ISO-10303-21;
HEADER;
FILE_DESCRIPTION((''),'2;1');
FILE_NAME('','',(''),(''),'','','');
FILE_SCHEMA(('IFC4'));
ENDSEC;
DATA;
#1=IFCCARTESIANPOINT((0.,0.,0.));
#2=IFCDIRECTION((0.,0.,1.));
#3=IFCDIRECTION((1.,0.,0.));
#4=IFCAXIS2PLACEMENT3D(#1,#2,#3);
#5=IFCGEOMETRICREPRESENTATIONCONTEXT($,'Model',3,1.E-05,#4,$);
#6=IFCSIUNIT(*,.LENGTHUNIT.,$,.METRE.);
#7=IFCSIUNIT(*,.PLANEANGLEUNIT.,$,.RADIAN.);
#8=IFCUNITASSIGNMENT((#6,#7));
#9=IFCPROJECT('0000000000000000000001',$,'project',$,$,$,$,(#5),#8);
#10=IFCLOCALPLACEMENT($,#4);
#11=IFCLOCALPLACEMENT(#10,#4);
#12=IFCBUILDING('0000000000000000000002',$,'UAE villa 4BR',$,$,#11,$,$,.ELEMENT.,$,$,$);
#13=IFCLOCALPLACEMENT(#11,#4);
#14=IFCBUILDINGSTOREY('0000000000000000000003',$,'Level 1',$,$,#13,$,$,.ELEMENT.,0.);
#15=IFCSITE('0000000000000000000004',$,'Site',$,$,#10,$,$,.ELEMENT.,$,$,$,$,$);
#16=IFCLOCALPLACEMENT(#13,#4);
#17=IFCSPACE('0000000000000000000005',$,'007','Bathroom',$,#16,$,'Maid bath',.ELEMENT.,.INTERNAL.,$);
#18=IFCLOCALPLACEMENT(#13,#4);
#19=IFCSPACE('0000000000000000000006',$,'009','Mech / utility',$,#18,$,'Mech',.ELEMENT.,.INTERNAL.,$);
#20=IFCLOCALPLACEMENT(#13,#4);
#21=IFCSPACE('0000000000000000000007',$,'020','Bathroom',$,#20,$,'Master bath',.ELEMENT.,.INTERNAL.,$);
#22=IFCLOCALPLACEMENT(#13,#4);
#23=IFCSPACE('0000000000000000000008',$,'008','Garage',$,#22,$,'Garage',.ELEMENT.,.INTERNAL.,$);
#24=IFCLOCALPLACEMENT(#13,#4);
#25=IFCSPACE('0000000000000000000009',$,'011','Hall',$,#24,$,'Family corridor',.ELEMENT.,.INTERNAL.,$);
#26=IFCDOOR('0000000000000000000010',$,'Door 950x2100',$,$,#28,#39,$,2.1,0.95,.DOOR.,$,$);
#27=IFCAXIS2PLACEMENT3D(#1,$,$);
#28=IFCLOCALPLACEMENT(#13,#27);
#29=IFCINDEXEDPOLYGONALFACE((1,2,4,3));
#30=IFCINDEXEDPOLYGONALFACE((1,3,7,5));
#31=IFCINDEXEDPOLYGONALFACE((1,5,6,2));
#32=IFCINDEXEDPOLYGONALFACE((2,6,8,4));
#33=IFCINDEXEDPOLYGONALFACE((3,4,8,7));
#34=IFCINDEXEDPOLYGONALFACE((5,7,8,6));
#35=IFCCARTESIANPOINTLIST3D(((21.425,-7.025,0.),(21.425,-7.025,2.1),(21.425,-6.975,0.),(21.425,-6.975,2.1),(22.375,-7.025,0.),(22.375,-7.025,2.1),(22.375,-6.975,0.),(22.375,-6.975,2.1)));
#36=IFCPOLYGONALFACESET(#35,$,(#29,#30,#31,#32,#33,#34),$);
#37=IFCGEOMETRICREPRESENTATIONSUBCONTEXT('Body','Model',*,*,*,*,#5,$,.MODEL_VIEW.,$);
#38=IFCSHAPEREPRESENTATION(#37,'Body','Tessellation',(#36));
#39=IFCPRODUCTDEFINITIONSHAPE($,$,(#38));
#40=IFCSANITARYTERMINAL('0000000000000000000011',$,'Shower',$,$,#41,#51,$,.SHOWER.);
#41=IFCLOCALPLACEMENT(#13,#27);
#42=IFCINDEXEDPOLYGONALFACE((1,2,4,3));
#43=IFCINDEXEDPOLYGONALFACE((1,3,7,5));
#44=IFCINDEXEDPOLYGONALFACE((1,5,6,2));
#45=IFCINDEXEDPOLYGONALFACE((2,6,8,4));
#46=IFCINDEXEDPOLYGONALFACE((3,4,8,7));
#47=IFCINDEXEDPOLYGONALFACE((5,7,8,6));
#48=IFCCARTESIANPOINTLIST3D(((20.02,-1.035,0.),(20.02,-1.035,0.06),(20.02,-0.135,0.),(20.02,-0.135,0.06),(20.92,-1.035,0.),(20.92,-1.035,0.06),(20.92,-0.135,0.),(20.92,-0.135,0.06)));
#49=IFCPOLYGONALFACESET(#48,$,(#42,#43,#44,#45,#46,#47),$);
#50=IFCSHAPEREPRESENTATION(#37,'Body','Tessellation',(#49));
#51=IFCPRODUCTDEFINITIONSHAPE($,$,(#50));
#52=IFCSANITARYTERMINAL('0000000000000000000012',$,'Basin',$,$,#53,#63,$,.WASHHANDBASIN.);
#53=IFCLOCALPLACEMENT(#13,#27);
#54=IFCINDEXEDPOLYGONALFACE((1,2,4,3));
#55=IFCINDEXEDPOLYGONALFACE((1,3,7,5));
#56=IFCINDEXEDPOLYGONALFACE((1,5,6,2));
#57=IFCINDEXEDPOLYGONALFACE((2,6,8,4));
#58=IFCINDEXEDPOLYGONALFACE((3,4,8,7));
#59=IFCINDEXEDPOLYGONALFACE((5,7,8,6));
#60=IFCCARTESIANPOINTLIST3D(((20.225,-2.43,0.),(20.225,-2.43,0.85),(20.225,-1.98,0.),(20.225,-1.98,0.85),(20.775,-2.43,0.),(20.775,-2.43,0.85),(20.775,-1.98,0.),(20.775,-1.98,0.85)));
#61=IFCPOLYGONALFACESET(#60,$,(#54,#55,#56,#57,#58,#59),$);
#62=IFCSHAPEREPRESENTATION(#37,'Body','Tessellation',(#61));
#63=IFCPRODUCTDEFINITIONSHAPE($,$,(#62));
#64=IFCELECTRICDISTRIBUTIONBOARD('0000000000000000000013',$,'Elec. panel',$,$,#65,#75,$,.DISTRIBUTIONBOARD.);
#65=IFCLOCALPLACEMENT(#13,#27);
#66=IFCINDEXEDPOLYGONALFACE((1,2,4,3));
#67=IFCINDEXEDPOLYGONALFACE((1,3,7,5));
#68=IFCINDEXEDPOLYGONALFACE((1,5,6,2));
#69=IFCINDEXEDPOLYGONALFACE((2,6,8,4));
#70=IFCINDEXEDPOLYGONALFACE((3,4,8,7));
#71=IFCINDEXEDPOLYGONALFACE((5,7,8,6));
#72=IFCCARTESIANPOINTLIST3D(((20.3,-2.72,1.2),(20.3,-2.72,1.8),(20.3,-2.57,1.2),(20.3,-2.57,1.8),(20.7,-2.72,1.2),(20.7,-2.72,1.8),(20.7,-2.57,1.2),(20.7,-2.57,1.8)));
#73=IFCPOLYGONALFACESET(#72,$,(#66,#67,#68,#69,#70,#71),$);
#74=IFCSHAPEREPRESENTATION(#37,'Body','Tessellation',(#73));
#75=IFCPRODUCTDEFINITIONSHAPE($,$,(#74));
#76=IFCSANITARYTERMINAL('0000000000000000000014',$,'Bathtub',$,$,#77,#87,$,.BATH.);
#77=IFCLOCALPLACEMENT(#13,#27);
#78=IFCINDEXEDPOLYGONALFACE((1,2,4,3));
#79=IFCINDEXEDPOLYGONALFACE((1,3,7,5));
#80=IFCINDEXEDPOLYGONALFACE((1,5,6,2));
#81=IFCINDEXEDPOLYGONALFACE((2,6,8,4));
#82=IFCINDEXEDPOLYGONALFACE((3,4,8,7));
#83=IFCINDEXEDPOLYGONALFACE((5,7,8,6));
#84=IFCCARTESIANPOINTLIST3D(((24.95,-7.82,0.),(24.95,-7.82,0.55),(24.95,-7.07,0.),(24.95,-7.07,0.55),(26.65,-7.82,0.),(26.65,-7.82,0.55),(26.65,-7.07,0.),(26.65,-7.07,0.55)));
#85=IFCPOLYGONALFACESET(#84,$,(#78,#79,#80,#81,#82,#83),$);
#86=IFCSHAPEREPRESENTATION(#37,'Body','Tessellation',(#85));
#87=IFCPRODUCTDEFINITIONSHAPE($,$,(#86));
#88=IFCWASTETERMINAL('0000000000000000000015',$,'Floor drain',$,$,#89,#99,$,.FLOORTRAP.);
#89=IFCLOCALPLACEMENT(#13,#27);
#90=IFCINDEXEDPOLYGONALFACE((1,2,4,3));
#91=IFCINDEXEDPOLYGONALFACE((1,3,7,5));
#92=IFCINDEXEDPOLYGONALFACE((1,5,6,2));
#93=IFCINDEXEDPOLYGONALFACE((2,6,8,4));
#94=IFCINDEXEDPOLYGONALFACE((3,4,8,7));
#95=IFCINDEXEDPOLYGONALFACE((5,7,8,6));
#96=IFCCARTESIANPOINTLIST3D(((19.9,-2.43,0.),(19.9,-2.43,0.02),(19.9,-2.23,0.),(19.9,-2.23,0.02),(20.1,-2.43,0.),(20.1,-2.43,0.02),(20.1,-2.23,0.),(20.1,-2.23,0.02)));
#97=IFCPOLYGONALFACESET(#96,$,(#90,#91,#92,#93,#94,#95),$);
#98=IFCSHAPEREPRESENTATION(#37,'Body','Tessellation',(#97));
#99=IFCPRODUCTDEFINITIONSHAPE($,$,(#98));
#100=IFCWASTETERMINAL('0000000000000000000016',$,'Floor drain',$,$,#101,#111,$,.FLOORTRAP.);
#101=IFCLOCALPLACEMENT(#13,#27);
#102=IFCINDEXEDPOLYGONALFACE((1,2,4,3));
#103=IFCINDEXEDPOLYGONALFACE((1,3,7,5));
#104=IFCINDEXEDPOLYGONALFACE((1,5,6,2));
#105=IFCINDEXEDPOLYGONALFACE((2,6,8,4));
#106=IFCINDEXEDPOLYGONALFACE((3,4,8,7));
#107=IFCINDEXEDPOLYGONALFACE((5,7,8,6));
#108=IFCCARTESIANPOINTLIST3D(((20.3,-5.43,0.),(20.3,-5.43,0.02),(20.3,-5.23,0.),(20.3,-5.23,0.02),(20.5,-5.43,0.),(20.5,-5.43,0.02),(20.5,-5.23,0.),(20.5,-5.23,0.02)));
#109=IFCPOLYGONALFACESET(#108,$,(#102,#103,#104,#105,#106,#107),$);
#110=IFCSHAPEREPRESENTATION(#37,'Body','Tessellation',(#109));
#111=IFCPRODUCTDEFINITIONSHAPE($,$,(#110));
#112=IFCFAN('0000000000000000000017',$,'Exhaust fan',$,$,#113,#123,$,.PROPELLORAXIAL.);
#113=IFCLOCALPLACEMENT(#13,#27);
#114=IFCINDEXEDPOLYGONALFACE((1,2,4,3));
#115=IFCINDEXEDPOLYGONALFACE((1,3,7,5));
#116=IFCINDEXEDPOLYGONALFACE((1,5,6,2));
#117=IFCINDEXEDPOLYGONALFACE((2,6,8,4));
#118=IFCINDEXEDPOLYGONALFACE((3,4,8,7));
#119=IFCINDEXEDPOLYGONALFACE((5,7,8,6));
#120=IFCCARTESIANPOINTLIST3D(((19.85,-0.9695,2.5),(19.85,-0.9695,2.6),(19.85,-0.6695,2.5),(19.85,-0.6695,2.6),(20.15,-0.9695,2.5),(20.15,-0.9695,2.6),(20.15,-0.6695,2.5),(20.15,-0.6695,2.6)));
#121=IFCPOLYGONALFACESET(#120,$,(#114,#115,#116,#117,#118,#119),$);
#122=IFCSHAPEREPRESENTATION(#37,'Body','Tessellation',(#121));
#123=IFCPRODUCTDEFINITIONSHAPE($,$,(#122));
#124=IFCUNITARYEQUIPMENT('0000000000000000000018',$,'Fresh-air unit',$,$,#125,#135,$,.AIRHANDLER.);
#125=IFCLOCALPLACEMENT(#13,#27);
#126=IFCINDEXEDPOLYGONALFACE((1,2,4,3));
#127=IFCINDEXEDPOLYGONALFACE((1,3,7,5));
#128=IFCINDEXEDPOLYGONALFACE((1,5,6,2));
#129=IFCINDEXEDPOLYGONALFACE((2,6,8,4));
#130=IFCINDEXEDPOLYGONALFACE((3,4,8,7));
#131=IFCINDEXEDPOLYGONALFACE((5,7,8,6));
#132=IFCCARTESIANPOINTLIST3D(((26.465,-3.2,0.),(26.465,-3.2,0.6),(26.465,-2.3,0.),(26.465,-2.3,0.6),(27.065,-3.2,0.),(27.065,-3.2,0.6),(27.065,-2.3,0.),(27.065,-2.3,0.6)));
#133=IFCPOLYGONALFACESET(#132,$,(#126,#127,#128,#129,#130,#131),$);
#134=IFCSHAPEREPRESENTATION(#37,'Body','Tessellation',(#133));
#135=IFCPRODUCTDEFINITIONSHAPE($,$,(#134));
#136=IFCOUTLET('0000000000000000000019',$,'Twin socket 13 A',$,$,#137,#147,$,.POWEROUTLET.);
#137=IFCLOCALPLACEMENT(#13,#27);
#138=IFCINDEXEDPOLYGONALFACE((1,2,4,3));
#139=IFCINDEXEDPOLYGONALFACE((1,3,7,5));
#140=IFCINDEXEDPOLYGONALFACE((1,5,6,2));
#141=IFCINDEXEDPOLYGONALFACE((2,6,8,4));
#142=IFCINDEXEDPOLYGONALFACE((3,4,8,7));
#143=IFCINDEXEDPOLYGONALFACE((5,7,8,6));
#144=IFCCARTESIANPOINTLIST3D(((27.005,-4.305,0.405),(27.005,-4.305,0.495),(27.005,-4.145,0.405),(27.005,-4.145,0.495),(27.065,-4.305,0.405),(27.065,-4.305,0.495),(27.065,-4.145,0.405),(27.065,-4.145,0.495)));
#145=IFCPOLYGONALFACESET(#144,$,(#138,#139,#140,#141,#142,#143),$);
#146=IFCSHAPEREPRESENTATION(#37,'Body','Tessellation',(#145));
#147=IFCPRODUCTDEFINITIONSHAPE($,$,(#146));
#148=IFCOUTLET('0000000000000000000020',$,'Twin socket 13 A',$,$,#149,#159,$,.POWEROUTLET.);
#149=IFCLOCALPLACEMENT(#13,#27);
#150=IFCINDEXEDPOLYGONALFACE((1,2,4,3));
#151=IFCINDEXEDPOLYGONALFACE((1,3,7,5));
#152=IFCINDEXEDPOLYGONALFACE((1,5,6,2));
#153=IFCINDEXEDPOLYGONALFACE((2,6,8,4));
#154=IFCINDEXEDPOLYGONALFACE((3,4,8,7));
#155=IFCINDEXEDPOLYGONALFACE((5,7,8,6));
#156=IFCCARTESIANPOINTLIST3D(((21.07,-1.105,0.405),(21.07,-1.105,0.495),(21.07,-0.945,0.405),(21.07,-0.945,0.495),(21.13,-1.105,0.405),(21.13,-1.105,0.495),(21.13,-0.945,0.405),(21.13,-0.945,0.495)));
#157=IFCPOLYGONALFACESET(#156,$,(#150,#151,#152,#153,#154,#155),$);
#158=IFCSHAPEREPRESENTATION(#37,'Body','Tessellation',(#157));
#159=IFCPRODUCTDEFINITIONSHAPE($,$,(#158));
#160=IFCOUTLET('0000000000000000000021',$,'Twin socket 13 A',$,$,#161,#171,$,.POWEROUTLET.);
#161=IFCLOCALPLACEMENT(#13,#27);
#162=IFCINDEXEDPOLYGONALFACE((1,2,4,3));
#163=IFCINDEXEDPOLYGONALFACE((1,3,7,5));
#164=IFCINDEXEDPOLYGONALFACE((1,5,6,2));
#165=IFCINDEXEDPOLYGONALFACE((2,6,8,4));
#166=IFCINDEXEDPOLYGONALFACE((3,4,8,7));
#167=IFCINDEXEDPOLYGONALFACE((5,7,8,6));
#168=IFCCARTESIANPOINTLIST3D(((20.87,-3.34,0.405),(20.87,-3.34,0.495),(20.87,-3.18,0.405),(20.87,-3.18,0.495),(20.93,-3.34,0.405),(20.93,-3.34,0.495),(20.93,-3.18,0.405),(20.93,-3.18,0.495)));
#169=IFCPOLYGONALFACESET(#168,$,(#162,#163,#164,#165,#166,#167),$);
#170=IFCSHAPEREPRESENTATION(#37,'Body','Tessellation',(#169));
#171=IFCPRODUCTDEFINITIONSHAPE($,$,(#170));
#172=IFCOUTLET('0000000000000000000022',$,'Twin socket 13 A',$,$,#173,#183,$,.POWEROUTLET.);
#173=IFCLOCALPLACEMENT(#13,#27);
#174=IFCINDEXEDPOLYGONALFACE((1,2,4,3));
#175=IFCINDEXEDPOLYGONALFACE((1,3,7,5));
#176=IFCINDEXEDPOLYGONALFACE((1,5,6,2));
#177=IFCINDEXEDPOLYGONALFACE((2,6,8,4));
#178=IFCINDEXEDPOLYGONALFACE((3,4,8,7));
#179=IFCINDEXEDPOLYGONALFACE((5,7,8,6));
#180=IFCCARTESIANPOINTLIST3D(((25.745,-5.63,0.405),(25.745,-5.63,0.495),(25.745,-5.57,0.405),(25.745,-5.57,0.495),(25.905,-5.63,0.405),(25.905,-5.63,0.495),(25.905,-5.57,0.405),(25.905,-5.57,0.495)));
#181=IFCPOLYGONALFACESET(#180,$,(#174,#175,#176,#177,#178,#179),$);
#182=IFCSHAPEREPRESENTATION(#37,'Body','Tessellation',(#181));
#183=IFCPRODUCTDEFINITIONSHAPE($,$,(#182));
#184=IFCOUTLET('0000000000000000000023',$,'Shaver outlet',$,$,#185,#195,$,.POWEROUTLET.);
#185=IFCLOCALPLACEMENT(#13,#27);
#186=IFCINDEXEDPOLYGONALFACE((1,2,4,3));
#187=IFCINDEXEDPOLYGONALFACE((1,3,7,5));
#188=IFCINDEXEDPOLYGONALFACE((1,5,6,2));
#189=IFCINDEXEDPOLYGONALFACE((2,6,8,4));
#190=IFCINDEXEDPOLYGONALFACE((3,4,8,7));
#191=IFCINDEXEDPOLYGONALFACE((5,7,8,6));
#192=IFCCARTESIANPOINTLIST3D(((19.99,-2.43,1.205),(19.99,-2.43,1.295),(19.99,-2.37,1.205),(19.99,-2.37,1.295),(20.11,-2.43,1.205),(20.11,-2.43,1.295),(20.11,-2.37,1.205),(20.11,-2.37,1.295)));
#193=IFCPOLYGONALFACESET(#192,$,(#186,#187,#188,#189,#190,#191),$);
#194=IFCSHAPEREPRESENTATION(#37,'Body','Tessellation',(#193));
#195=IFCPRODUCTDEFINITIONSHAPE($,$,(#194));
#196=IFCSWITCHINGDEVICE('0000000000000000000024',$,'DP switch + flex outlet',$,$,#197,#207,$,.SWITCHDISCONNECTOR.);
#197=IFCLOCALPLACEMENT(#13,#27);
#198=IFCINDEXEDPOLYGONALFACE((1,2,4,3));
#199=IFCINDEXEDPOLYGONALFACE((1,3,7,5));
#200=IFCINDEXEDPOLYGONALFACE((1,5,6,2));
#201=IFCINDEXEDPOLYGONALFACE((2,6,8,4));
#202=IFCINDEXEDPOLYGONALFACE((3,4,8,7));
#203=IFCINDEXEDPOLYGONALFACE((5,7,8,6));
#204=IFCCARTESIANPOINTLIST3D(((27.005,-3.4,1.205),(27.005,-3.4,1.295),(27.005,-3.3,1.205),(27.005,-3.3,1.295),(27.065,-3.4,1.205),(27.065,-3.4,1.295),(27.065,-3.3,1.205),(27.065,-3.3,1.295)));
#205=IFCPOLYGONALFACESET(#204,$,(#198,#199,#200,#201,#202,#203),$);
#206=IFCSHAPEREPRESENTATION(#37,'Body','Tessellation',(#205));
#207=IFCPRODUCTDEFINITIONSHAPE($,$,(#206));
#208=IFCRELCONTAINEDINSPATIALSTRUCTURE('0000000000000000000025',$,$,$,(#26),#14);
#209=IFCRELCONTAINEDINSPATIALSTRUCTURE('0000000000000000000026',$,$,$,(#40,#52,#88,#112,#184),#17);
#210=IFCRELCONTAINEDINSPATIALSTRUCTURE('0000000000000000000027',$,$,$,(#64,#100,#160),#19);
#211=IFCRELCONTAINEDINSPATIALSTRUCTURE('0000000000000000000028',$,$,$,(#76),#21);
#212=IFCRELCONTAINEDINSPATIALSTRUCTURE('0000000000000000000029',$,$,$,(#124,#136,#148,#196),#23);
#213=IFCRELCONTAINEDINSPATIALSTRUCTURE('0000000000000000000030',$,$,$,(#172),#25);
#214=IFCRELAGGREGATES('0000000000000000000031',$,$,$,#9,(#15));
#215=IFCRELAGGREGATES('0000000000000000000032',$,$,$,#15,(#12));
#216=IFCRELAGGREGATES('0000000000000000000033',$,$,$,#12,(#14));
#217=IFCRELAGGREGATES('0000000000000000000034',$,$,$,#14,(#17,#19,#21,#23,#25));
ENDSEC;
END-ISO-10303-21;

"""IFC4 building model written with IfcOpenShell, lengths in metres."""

from ifc_helpers import new_model, si_unit, frame, origin, origin_with_axes, origin_2d, place, context, subcontext, project, spatial, rectangle, extrude, element, save


model = new_model("IFC4")

# Units and contexts
model_context = context("Model", 3, precision=1e-05, world=origin_with_axes())
body_context = subcontext(model_context, "Body", "Model", "MODEL_VIEW")
ifc_project = project(units=[si_unit("LENGTHUNIT", "METRE"), si_unit("PLANEANGLEUNIT", "RADIAN")], contexts=[model_context])

# Site, building, storey
site_placement = place(None, origin_with_axes())
site = spatial("IfcSite", under=ifc_project, at=site_placement, Name="Site", CompositionType="ELEMENT")
building_placement = place(site_placement, origin_with_axes())
building = spatial("IfcBuilding", under=site, at=building_placement, Name="UAE villa 4BR", CompositionType="ELEMENT")
storey_placement = place(building_placement, origin_with_axes())
storey = spatial("IfcBuildingStorey", under=building, at=storey_placement, Name="Level 1", CompositionType="ELEMENT", Elevation=0.0)

# Door
door_1_placement = place(storey_placement, frame((21.9, -7.0, 0.0), z_axis=(0.0, 0.0, 1.0), x_axis=(-1.0, 0.0, 0.0)))
element("IfcDoor", 1, at=door_1_placement, inside=storey, Name="Door 950x2100", OverallHeight=2.1, OverallWidth=0.95, PredefinedType="DOOR", context=body_context, shape_type="SweptSolid", body=[
    extrude(rectangle(XDim=0.95, YDim=0.05, at=origin_2d()), origin(), (0.0, 0.0, 1.0), 2.1),
])

# Shared definitions
space_1_placement = place(storey_placement, origin_with_axes())
space_1 = spatial("IfcSpace", under=storey, at=space_1_placement, Name="007", Description="Bathroom", LongName="Maid bath", CompositionType="ELEMENT", PredefinedType="INTERNAL")

# Sanitary terminals
sanitary_terminal_1_placement = place(storey_placement, frame((20.47, -0.585, 0.0), z_axis=(0.0, 0.0, 1.0), x_axis=(1.0, 0.0, 0.0)))
element("IfcSanitaryTerminal", 2, at=sanitary_terminal_1_placement, inside=space_1, Name="Shower", PredefinedType="SHOWER", context=body_context, shape_type="SweptSolid", body=[
    extrude(rectangle(XDim=0.9, YDim=0.9, at=origin_2d()), origin(), (0.0, 0.0, 1.0), 0.06),
])
sanitary_terminal_2_placement = place(storey_placement, frame((20.5, -2.205, 0.0), z_axis=(0.0, 0.0, 1.0), x_axis=(-1.0, 0.0, 0.0)))
element("IfcSanitaryTerminal", 3, at=sanitary_terminal_2_placement, inside=space_1, Name="Basin", PredefinedType="WASHHANDBASIN", context=body_context, shape_type="SweptSolid", body=[
    extrude(rectangle(XDim=0.55, YDim=0.45, at=origin_2d()), origin(), (0.0, 0.0, 1.0), 0.85),
])

# Shared definitions
space_2_placement = place(storey_placement, origin_with_axes())
space_2 = spatial("IfcSpace", under=storey, at=space_2_placement, Name="009", Description="Mech / utility", LongName="Mech", CompositionType="ELEMENT", PredefinedType="INTERNAL")

# Electric distribution board
electric_distribution_board_placement = place(storey_placement, frame((20.5, -2.645, 1.2), z_axis=(0.0, 0.0, 1.0), x_axis=(1.0, 0.0, 0.0)))
element("IfcElectricDistributionBoard", 4, at=electric_distribution_board_placement, inside=space_2, Name="Elec. panel", PredefinedType="DISTRIBUTIONBOARD", context=body_context, shape_type="SweptSolid", body=[
    extrude(rectangle(XDim=0.4, YDim=0.15, at=origin_2d()), origin(), (0.0, 0.0, 1.0), 0.6),
])

# Shared definitions
space_3_placement = place(storey_placement, origin_with_axes())
space_3 = spatial("IfcSpace", under=storey, at=space_3_placement, Name="020", Description="Bathroom", LongName="Master bath", CompositionType="ELEMENT", PredefinedType="INTERNAL")

# Sanitary terminal
sanitary_terminal_3_placement = place(storey_placement, frame((25.8, -7.445, 0.0), z_axis=(0.0, 0.0, 1.0), x_axis=(1.0, 0.0, 0.0)))
element("IfcSanitaryTerminal", 5, at=sanitary_terminal_3_placement, inside=space_3, Name="Bathtub", PredefinedType="BATH", context=body_context, shape_type="SweptSolid", body=[
    extrude(rectangle(XDim=1.7, YDim=0.75, at=origin_2d()), origin(), (0.0, 0.0, 1.0), 0.55),
])

# Waste terminals
waste_terminal_1_placement = place(storey_placement, frame((20.0, -2.33, 0.0), z_axis=(0.0, 0.0, 1.0), x_axis=(-1.0, 0.0, 0.0)))
element("IfcWasteTerminal", 6, at=waste_terminal_1_placement, inside=space_1, Name="Floor drain", PredefinedType="FLOORTRAP", context=body_context, shape_type="SweptSolid", body=[
    extrude(rectangle(XDim=0.2, YDim=0.2, at=origin_2d()), origin(), (0.0, 0.0, 1.0), 0.02),
])
waste_terminal_2_placement = place(storey_placement, frame((20.4, -5.33, 0.0), z_axis=(0.0, 0.0, 1.0), x_axis=(-1.0, 0.0, 0.0)))
element("IfcWasteTerminal", 7, at=waste_terminal_2_placement, inside=space_2, Name="Floor drain", PredefinedType="FLOORTRAP", context=body_context, shape_type="SweptSolid", body=[
    extrude(rectangle(XDim=0.2, YDim=0.2, at=origin_2d()), origin(), (0.0, 0.0, 1.0), 0.02),
])

# Fan
fan_placement = place(storey_placement, frame((20.0, -0.8195, 2.5), z_axis=(0.0, 0.0, 1.0), x_axis=(1.0, 0.0, 0.0)))
element("IfcFan", 8, at=fan_placement, inside=space_1, Name="Exhaust fan", PredefinedType="PROPELLORAXIAL", context=body_context, shape_type="SweptSolid", body=[
    extrude(rectangle(XDim=0.3, YDim=0.3, at=origin_2d()), origin(), (0.0, 0.0, 1.0), 0.1),
])

# Shared definitions
space_4_placement = place(storey_placement, origin_with_axes())
space_4 = spatial("IfcSpace", under=storey, at=space_4_placement, Name="008", Description="Garage", LongName="Garage", CompositionType="ELEMENT", PredefinedType="INTERNAL")

# Unitary equipment
unitary_equipment_placement = place(storey_placement, frame((26.765, -2.75, 0.0), z_axis=(0.0, 0.0, 1.0), x_axis=(0.0, -1.0, 0.0)))
element("IfcUnitaryEquipment", 9, at=unitary_equipment_placement, inside=space_4, Name="Fresh-air unit", PredefinedType="AIRHANDLER", context=body_context, shape_type="SweptSolid", body=[
    extrude(rectangle(XDim=0.9, YDim=0.6, at=origin_2d()), origin(), (0.0, 0.0, 1.0), 0.6),
])

# Outlets
for number, where, z_axis, x_axis, name in (
    (10, (27.035, -4.225, 0.405), (0.0, 0.0, 1.0), (0.0, -1.0, 0.0), "Twin socket 13 A"),
    (11, (21.1, -1.025, 0.405), (0.0, 0.0, 1.0), (0.0, 1.0, 0.0), "Twin socket 13 A"),
):
    element("IfcOutlet", number, at=place(storey_placement, frame(where, z_axis=z_axis, x_axis=x_axis)), inside=space_4, Name=name, PredefinedType="POWEROUTLET", context=body_context, shape_type="SweptSolid", body=[
        extrude(rectangle(XDim=0.16, YDim=0.06, at=origin_2d()), origin(), (0.0, 0.0, 1.0), 0.09),
    ])
outlet_1_placement = place(storey_placement, frame((20.9, -3.26, 0.405), z_axis=(0.0, 0.0, 1.0), x_axis=(0.0, -1.0, 0.0)))
element("IfcOutlet", 12, at=outlet_1_placement, inside=space_2, Name="Twin socket 13 A", PredefinedType="POWEROUTLET", context=body_context, shape_type="SweptSolid", body=[
    extrude(rectangle(XDim=0.16, YDim=0.06, at=origin_2d()), origin(), (0.0, 0.0, 1.0), 0.09),
])

# Shared definitions
space_5_placement = place(storey_placement, origin_with_axes())
space_5 = spatial("IfcSpace", under=storey, at=space_5_placement, Name="011", Description="Hall", LongName="Family corridor", CompositionType="ELEMENT", PredefinedType="INTERNAL")

# Outlets
outlet_2_placement = place(storey_placement, frame((25.825, -5.6, 0.405), z_axis=(0.0, 0.0, 1.0), x_axis=(1.0, 0.0, 0.0)))
element("IfcOutlet", 13, at=outlet_2_placement, inside=space_5, Name="Twin socket 13 A", PredefinedType="POWEROUTLET", context=body_context, shape_type="SweptSolid", body=[
    extrude(rectangle(XDim=0.16, YDim=0.06, at=origin_2d()), origin(), (0.0, 0.0, 1.0), 0.09),
])
outlet_3_placement = place(storey_placement, frame((20.05, -2.4, 1.205), z_axis=(0.0, 0.0, 1.0), x_axis=(-1.0, 0.0, 0.0)))
element("IfcOutlet", 14, at=outlet_3_placement, inside=space_1, Name="Shaver outlet", PredefinedType="POWEROUTLET", context=body_context, shape_type="SweptSolid", body=[
    extrude(rectangle(XDim=0.12, YDim=0.06, at=origin_2d()), origin(), (0.0, 0.0, 1.0), 0.09),
])

# Switching device
switching_device_placement = place(storey_placement, frame((27.035, -3.35, 1.205), z_axis=(0.0, 0.0, 1.0), x_axis=(0.0, -1.0, 0.0)))
element("IfcSwitchingDevice", 15, at=switching_device_placement, inside=space_4, Name="DP switch + flex outlet", PredefinedType="SWITCHDISCONNECTOR", context=body_context, shape_type="SweptSolid", body=[
    extrude(rectangle(XDim=0.1, YDim=0.06, at=origin_2d()), origin(), (0.0, 0.0, 1.0), 0.09),
])

save(model, "model.ifc")
